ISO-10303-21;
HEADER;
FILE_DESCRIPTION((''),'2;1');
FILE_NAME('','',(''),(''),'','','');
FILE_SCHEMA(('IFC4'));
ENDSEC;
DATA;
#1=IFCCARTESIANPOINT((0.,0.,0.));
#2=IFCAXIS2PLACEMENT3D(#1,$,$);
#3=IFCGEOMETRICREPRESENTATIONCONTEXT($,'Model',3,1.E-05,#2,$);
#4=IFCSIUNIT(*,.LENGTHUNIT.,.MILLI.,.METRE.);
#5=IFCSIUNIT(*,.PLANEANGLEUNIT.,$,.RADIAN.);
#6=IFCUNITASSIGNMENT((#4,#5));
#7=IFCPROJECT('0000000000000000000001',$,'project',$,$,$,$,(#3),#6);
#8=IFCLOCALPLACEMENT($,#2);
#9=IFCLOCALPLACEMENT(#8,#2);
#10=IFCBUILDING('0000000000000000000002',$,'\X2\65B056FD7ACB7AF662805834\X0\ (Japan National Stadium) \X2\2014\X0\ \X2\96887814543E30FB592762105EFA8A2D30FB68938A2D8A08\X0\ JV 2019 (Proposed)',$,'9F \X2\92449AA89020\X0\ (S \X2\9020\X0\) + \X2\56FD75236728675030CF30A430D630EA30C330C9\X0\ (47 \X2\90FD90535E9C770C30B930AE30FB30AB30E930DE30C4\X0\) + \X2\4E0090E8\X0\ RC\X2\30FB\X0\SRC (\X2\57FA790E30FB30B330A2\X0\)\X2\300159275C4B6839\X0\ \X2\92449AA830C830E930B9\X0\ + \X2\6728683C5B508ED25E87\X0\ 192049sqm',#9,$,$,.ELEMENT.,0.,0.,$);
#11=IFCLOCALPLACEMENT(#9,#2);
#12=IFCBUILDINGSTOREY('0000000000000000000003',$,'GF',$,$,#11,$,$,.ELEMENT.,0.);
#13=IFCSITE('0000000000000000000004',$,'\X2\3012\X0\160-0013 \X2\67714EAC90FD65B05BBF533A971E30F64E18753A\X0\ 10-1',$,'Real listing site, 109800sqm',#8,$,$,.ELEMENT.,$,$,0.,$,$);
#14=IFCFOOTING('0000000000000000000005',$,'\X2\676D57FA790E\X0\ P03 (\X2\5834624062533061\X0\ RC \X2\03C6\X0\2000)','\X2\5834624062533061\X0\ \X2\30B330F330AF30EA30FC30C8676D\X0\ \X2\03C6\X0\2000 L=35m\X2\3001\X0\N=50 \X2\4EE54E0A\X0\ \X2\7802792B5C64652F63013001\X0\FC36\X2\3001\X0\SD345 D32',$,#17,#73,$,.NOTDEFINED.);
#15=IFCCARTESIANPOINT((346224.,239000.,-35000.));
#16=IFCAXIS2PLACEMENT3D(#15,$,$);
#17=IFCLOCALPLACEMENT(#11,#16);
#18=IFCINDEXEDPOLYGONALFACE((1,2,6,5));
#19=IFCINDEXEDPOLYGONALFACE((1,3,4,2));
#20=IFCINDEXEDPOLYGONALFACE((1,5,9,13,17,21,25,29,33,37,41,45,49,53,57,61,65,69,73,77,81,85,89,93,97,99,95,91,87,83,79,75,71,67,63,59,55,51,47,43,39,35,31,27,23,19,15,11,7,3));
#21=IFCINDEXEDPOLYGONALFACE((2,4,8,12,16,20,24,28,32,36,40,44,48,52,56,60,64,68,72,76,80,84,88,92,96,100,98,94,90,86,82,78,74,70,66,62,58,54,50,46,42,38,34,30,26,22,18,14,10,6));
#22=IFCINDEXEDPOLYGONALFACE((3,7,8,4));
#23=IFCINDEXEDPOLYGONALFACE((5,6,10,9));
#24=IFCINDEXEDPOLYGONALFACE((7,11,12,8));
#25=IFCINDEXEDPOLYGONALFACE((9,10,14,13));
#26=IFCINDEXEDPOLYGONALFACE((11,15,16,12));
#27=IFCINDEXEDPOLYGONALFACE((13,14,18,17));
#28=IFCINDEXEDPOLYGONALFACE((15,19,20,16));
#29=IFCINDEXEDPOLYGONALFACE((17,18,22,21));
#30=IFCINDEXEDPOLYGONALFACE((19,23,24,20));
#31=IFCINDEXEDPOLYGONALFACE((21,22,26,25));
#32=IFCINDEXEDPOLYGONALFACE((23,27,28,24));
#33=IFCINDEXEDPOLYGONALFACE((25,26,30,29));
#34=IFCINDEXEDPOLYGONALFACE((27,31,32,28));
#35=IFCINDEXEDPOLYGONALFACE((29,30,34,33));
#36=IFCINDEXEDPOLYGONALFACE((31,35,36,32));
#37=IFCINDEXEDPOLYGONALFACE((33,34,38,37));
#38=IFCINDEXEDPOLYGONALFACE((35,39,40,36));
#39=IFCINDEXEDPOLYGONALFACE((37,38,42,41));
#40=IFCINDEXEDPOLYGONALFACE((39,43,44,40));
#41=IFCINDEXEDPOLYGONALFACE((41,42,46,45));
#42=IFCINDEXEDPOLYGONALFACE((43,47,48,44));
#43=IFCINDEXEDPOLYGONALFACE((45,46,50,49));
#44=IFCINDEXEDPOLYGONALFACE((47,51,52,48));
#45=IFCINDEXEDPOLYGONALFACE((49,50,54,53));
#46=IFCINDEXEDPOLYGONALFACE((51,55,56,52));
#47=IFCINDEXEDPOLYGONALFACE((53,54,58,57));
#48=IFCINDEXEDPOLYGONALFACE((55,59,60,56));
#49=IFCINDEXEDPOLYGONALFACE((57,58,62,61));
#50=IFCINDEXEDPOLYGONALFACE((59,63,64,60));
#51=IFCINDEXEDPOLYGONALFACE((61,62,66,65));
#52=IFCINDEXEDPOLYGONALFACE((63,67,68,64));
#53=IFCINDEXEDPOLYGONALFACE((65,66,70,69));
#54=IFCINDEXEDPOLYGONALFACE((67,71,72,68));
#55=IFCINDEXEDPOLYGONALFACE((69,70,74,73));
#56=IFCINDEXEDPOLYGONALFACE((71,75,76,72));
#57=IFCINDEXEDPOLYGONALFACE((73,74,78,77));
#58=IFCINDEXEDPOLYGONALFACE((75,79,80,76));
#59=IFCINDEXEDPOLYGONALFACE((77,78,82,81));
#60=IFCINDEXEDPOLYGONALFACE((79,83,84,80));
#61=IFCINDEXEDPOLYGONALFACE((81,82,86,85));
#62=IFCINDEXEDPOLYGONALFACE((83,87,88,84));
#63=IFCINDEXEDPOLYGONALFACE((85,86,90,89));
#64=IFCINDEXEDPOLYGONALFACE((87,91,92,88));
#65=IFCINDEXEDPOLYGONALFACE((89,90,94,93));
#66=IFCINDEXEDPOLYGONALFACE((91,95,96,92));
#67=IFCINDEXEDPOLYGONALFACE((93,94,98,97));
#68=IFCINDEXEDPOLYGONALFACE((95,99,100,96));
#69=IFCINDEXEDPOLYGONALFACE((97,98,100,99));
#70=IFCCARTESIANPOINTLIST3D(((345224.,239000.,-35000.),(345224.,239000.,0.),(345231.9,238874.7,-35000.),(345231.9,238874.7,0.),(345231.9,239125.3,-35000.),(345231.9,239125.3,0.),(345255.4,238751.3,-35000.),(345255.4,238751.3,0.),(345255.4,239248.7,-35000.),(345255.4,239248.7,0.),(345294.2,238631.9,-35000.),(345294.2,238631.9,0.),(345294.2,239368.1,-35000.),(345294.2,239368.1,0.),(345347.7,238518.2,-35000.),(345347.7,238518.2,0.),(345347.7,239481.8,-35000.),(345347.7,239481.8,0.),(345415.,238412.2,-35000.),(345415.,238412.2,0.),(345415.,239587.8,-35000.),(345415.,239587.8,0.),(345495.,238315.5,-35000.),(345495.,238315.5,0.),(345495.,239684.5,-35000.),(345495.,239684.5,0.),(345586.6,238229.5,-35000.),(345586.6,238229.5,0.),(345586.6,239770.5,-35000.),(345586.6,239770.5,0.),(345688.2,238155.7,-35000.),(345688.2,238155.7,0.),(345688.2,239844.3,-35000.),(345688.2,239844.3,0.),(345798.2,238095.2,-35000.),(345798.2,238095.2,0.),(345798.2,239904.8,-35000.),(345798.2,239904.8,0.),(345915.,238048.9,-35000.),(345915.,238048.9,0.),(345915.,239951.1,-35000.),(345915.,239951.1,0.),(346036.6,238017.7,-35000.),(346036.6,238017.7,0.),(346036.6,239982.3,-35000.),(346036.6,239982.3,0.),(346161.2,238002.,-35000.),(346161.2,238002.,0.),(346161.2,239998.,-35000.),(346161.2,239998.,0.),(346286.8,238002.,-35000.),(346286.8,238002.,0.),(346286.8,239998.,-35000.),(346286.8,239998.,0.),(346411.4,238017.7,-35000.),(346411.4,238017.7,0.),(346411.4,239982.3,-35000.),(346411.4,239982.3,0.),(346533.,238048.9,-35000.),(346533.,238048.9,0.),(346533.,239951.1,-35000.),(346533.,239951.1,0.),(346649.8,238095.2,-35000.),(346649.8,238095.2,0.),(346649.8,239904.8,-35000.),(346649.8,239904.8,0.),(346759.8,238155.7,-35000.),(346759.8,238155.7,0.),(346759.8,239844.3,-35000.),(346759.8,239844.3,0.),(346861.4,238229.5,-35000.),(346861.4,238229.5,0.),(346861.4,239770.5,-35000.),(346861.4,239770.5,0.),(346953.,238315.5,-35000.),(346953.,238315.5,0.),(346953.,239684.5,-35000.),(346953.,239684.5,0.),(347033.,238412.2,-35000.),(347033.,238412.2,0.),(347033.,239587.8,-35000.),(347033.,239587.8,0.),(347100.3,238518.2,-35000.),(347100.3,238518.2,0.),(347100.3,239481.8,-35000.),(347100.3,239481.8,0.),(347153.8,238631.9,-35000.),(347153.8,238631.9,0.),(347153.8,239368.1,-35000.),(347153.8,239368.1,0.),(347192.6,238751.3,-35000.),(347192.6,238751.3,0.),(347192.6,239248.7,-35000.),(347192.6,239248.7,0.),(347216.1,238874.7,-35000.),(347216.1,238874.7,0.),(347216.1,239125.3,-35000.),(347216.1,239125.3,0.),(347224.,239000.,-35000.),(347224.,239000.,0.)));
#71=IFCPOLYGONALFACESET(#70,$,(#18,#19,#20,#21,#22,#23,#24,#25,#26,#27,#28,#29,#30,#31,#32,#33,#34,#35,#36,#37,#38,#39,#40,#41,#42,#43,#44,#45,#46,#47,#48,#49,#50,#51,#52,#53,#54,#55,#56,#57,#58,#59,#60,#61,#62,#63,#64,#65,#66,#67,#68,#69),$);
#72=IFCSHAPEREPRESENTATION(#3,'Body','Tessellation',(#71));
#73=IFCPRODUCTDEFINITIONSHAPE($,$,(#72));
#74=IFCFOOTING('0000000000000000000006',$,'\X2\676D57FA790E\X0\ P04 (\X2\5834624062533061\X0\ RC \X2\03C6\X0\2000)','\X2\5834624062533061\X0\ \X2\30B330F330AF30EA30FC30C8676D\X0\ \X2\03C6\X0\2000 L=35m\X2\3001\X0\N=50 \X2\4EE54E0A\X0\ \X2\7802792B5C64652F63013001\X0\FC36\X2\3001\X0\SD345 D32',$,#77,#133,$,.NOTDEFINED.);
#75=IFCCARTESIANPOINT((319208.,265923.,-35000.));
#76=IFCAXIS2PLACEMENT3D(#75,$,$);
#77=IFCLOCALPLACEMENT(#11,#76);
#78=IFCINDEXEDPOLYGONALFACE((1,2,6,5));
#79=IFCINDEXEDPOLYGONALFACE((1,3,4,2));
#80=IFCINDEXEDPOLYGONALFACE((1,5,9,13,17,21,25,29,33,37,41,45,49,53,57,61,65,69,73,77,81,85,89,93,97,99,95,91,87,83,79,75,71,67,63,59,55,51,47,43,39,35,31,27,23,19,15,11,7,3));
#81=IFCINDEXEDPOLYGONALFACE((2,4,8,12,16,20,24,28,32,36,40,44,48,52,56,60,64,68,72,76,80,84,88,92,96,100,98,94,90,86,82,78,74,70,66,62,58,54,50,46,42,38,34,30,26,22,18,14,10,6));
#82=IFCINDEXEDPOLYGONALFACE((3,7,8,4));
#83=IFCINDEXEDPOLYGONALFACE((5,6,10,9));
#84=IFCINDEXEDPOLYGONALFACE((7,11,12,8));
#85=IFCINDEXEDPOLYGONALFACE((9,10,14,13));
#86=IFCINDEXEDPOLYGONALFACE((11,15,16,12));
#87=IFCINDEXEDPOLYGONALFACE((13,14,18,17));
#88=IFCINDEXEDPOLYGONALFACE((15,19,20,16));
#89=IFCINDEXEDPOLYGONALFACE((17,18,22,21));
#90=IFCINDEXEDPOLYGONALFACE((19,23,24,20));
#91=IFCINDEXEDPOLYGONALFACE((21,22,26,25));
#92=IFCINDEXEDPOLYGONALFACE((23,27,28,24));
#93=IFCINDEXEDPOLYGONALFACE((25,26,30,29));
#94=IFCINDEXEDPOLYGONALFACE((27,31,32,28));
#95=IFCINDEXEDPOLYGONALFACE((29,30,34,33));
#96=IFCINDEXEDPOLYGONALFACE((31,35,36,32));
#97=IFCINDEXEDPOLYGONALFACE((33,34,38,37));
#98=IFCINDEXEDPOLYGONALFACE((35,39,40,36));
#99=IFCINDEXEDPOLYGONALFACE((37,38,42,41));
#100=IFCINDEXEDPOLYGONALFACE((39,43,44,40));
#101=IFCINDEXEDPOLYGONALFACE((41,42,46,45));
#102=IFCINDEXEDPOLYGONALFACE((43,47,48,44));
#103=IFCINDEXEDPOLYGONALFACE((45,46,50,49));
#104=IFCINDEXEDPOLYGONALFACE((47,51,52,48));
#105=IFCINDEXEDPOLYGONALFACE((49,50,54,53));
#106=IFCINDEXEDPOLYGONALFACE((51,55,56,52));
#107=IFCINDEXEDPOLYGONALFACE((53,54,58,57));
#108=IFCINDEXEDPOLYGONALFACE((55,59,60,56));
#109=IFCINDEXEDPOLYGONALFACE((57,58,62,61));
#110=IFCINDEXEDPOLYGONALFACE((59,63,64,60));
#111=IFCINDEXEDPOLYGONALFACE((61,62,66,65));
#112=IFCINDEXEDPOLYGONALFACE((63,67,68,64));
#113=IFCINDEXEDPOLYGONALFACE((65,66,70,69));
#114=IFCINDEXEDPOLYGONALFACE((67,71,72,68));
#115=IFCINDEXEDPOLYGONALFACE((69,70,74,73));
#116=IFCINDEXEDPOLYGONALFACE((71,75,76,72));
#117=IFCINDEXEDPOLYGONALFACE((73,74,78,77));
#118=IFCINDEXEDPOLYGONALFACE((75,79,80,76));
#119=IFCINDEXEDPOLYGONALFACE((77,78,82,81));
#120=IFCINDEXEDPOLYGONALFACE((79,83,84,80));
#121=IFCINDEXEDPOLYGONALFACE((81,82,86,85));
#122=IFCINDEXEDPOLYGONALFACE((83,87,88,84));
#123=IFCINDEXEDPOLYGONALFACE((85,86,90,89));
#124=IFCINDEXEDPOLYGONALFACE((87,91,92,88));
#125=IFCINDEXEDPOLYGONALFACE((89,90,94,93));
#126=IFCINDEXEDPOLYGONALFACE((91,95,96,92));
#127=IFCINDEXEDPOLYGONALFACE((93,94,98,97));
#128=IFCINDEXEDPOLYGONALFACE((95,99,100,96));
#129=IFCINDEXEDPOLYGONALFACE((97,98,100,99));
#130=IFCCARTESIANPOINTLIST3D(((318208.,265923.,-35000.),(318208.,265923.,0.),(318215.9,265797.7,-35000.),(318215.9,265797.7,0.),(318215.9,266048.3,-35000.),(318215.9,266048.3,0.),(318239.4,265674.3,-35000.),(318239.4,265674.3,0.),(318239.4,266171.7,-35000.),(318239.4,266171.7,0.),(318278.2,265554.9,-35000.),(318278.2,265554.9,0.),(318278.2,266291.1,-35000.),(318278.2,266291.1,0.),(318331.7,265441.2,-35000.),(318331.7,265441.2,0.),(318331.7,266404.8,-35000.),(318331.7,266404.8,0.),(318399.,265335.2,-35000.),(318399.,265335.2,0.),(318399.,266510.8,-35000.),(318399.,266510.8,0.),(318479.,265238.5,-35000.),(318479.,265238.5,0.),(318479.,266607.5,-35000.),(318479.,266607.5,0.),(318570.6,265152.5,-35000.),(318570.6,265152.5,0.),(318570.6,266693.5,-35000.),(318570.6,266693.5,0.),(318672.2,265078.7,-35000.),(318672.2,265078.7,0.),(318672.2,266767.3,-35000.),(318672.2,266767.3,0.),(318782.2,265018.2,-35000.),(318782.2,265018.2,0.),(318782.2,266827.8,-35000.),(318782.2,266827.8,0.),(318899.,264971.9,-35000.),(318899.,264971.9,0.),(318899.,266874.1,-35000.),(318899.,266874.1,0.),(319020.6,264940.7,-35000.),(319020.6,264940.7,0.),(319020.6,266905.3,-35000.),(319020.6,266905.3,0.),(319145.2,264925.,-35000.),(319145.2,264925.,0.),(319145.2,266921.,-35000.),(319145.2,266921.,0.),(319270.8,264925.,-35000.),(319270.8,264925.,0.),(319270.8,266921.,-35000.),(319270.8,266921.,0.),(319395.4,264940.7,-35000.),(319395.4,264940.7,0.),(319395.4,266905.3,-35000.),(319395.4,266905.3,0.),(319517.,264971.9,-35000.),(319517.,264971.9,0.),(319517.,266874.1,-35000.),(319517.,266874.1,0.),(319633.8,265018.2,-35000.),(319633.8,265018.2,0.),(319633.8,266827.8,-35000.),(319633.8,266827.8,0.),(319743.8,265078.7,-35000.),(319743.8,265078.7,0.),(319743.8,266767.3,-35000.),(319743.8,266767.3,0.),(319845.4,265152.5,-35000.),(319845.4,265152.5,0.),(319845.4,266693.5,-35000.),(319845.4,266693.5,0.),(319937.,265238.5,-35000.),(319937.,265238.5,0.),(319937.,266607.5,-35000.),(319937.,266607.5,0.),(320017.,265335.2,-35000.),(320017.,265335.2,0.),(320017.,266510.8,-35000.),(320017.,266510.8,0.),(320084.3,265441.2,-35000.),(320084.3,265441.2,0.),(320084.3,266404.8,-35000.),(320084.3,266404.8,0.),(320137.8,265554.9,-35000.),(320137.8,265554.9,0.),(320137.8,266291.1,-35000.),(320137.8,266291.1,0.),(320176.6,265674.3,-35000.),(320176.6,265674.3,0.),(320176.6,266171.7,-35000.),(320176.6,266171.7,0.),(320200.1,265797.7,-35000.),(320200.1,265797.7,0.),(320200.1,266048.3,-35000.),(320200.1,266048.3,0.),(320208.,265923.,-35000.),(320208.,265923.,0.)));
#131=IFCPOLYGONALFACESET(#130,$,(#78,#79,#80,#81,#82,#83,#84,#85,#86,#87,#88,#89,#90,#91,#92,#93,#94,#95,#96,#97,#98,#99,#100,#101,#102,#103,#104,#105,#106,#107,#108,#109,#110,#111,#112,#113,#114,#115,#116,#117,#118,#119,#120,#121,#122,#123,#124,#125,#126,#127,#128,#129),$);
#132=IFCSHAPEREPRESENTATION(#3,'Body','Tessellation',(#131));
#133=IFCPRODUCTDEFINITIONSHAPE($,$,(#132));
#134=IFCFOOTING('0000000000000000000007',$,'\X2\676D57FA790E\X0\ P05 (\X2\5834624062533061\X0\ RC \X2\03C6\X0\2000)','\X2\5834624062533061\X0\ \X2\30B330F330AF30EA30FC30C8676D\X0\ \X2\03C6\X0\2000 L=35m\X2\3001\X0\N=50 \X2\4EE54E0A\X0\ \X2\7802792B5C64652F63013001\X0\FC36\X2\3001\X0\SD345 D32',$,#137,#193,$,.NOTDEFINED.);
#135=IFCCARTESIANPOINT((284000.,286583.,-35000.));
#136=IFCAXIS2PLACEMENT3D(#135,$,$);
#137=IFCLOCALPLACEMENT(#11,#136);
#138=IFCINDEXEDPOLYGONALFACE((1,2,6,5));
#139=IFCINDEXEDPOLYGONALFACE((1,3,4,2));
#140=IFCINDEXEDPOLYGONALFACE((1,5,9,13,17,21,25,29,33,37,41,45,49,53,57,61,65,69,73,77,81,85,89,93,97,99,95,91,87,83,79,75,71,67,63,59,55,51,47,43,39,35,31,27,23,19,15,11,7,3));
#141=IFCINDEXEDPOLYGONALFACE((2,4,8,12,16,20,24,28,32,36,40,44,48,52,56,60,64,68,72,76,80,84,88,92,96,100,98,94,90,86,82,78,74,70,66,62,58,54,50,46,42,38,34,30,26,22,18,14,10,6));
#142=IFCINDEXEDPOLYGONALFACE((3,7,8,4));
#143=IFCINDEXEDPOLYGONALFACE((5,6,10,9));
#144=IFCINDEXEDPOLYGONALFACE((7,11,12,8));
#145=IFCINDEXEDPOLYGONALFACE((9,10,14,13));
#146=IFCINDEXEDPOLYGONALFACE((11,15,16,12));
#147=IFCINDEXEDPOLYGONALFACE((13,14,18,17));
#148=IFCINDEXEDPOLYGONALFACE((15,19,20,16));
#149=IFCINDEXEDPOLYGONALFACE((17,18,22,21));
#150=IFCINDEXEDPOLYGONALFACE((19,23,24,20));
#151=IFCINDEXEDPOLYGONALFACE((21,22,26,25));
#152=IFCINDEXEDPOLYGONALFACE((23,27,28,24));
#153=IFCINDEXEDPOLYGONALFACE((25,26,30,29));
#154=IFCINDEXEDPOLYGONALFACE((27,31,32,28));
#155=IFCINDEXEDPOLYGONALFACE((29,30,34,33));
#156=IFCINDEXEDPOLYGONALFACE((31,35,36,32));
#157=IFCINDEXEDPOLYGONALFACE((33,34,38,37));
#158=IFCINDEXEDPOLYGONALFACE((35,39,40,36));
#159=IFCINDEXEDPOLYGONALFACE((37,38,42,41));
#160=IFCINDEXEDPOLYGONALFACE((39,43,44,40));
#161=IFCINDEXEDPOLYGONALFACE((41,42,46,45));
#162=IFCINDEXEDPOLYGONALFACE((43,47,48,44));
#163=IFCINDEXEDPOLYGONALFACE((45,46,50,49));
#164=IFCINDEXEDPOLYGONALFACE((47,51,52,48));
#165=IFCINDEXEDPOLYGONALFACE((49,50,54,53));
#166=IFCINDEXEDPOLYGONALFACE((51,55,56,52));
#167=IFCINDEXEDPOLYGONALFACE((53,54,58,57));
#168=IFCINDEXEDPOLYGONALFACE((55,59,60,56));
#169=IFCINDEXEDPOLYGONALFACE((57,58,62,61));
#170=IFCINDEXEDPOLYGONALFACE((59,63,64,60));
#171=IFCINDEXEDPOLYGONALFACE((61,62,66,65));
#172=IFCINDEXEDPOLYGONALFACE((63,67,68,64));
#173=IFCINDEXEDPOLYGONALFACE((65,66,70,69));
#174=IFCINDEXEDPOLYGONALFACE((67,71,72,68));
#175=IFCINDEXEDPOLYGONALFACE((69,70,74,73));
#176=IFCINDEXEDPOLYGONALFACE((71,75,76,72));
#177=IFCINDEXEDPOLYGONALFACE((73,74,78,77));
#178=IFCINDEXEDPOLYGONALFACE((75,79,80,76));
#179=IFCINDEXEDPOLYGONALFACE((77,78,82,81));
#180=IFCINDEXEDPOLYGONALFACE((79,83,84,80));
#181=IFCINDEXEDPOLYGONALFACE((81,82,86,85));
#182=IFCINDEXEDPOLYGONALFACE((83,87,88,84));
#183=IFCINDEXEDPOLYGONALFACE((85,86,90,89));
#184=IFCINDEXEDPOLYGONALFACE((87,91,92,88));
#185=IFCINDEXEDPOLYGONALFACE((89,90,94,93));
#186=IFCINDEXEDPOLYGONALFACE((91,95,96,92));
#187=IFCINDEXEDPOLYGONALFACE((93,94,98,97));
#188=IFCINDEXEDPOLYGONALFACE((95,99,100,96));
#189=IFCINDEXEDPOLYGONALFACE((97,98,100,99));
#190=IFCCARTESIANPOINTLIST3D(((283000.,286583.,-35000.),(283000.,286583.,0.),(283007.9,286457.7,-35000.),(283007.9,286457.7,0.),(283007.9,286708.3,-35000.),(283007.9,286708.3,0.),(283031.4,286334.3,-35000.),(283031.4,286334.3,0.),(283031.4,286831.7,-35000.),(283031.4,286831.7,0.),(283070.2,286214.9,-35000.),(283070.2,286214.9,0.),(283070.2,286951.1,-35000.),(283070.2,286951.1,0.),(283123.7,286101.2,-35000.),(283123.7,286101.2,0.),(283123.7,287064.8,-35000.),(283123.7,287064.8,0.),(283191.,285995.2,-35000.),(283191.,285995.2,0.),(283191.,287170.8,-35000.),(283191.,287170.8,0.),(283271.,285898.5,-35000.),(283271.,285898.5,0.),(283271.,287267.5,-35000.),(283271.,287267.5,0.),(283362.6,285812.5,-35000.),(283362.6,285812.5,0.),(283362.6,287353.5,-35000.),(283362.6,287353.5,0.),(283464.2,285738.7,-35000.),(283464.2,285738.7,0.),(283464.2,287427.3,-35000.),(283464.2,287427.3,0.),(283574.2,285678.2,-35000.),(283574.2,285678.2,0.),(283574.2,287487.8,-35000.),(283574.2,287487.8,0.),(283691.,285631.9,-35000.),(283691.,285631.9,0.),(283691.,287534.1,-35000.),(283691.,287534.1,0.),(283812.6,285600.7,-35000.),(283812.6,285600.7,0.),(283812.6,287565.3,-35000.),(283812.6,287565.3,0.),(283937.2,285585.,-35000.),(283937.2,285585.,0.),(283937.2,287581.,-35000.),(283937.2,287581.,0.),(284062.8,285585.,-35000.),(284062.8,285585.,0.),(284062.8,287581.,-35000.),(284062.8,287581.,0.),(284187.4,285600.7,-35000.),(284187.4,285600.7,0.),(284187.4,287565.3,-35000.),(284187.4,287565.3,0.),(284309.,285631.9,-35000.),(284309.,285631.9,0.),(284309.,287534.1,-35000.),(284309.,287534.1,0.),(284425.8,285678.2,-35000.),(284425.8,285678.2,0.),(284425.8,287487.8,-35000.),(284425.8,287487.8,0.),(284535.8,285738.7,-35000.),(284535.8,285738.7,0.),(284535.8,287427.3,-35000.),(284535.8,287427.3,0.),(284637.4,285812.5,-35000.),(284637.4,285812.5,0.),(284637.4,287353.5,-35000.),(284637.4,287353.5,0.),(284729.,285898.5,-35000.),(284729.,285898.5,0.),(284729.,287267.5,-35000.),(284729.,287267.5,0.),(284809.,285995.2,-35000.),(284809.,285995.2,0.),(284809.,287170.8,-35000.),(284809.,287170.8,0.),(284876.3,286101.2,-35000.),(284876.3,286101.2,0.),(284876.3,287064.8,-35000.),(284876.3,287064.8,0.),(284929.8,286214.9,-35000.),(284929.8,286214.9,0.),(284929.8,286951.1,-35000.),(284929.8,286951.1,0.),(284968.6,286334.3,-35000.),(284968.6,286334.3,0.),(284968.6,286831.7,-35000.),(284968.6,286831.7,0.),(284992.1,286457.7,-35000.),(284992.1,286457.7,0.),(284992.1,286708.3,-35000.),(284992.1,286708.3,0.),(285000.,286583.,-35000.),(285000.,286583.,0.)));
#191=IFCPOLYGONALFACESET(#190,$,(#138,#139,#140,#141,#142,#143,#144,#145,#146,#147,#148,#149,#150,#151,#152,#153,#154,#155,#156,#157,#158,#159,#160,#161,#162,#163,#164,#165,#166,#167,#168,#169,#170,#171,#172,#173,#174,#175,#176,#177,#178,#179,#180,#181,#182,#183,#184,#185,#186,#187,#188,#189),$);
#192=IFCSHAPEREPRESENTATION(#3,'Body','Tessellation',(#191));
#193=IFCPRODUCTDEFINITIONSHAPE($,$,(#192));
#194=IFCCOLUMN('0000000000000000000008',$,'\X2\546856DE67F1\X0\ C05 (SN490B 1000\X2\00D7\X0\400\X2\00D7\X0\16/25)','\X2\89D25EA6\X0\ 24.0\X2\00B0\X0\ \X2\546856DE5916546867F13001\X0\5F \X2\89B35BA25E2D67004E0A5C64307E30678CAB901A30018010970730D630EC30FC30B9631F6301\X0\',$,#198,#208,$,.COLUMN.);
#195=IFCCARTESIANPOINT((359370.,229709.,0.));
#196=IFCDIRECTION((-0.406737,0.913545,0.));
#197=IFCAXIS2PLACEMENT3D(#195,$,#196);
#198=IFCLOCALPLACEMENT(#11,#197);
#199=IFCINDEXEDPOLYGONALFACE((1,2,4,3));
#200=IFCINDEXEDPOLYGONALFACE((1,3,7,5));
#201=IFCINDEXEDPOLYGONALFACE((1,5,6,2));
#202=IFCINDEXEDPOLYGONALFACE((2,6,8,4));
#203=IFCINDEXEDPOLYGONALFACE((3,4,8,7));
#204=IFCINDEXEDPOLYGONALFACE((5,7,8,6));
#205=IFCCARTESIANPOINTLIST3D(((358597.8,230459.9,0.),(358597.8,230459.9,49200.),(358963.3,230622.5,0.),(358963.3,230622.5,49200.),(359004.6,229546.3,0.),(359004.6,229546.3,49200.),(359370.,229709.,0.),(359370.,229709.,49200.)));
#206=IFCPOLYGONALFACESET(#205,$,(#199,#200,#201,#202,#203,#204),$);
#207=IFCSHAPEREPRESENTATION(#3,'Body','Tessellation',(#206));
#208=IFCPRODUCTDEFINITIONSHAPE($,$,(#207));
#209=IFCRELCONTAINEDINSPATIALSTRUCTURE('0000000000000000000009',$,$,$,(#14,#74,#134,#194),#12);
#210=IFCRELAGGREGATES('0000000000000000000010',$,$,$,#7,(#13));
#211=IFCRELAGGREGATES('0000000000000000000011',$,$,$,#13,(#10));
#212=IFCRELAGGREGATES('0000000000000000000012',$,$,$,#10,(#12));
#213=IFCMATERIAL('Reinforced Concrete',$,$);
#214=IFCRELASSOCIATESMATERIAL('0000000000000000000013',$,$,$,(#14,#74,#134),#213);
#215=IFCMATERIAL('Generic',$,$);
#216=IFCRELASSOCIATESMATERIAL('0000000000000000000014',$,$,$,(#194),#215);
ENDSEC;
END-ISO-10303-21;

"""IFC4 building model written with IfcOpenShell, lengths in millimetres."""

from ifc_helpers import new_model, si_unit, frame, frame_2d, origin, origin_2d, place, context, project, spatial, rectangle, circle, extrude, material, element, save


model = new_model("IFC4")

# Units and contexts
model_context = context("Model", 3, precision=1e-05, world=origin())
ifc_project = project(units=[si_unit("LENGTHUNIT", "METRE", prefix="MILLI"), si_unit("PLANEANGLEUNIT", "RADIAN")], contexts=[model_context])

# Site, building, storey
site_placement = place(None, origin())
site = spatial("IfcSite", under=ifc_project, at=site_placement, Name="〒160-0013 東京都新宿区霞ヶ丘町 10-1", ObjectType="Real listing site, 109800sqm", CompositionType="ELEMENT", RefElevation=0.0)
building_placement = place(site_placement, origin())
building = spatial("IfcBuilding", under=site, at=building_placement, Name="新国立競技場 (Japan National Stadium) — 隈研吾・大成建設・梓設計 JV 2019 (Proposed)", ObjectType="9F 鉄骨造 (S 造) + 国産木材ハイブリッド (47 都道府県スギ・カラマツ) + 一部 RC・SRC (基礎・コア)、大屋根 鉄骨トラス + 木格子軒庇 192049sqm", CompositionType="ELEMENT", ElevationOfRefHeight=0.0, ElevationOfTerrain=0.0)
storey_placement = place(building_placement, origin())
storey = spatial("IfcBuildingStorey", under=building, at=storey_placement, Name="GF", CompositionType="ELEMENT", Elevation=0.0)

# Footings
ifc_material_1 = material(Name="Reinforced Concrete")
footing_1_placement = place(storey_placement, frame((346224.0, 239000.0, -35000.0)))
element("IfcFooting", 1, at=footing_1_placement, inside=storey, material=ifc_material_1, Name="杭基礎 P03 (場所打ち RC φ2000)", Description="場所打ち コンクリート杭 φ2000 L=35m、N=50 以上 砂礫層支持、FC36、SD345 D32", PredefinedType="NOTDEFINED", context=model_context, shape_type="SweptSolid", body=[
    extrude(circle(Radius=1000.0, at=origin_2d()), frame((346224.0, 239000.0, -35000.0)), (0.0, 0.0, 1.0), 35000.0),
])
footing_2_placement = place(storey_placement, frame((319208.0, 265923.0, -35000.0)))
element("IfcFooting", 2, at=footing_2_placement, inside=storey, material=ifc_material_1, Name="杭基礎 P04 (場所打ち RC φ2000)", Description="場所打ち コンクリート杭 φ2000 L=35m、N=50 以上 砂礫層支持、FC36、SD345 D32", PredefinedType="NOTDEFINED", context=model_context, shape_type="SweptSolid", body=[
    extrude(circle(Radius=1000.0, at=origin_2d()), frame((319208.0, 265923.0, -35000.0)), (0.0, 0.0, 1.0), 35000.0),
])
footing_3_placement = place(storey_placement, frame((284000.0, 286583.0, -35000.0)))
element("IfcFooting", 3, at=footing_3_placement, inside=storey, material=ifc_material_1, Name="杭基礎 P05 (場所打ち RC φ2000)", Description="場所打ち コンクリート杭 φ2000 L=35m、N=50 以上 砂礫層支持、FC36、SD345 D32", PredefinedType="NOTDEFINED", context=model_context, shape_type="SweptSolid", body=[
    extrude(circle(Radius=1000.0, at=origin_2d()), frame((284000.0, 286583.0, -35000.0)), (0.0, 0.0, 1.0), 35000.0),
])

# Column
ifc_material_2 = material(Name="Generic")
column_1_placement = place(storey_placement, frame((359370.0, 229709.0, 0.0), x_axis=(-0.406737, 0.913545, 0.0)))
element("IfcColumn", 4, at=column_1_placement, inside=storey, material=ifc_material_2, Name="周回柱 C05 (SN490B 1000×400×16/25)", Description="角度 24.0° 周回外周柱、5F 観客席最上層まで貫通、耐震ブレース挟持", PredefinedType="COLUMN", context=model_context, shape_type="SweptSolid", body=[
    extrude(rectangle(XDim=1000.0, YDim=400.0, at=frame_2d((500.0, 200.0))), frame((359370.0, 229709.0, 0.0), x_axis=(-0.406737, 0.913545, 0.0)), (0.0, 0.0, 1.0), 49200.0),
])

save(model, "model.ifc")
